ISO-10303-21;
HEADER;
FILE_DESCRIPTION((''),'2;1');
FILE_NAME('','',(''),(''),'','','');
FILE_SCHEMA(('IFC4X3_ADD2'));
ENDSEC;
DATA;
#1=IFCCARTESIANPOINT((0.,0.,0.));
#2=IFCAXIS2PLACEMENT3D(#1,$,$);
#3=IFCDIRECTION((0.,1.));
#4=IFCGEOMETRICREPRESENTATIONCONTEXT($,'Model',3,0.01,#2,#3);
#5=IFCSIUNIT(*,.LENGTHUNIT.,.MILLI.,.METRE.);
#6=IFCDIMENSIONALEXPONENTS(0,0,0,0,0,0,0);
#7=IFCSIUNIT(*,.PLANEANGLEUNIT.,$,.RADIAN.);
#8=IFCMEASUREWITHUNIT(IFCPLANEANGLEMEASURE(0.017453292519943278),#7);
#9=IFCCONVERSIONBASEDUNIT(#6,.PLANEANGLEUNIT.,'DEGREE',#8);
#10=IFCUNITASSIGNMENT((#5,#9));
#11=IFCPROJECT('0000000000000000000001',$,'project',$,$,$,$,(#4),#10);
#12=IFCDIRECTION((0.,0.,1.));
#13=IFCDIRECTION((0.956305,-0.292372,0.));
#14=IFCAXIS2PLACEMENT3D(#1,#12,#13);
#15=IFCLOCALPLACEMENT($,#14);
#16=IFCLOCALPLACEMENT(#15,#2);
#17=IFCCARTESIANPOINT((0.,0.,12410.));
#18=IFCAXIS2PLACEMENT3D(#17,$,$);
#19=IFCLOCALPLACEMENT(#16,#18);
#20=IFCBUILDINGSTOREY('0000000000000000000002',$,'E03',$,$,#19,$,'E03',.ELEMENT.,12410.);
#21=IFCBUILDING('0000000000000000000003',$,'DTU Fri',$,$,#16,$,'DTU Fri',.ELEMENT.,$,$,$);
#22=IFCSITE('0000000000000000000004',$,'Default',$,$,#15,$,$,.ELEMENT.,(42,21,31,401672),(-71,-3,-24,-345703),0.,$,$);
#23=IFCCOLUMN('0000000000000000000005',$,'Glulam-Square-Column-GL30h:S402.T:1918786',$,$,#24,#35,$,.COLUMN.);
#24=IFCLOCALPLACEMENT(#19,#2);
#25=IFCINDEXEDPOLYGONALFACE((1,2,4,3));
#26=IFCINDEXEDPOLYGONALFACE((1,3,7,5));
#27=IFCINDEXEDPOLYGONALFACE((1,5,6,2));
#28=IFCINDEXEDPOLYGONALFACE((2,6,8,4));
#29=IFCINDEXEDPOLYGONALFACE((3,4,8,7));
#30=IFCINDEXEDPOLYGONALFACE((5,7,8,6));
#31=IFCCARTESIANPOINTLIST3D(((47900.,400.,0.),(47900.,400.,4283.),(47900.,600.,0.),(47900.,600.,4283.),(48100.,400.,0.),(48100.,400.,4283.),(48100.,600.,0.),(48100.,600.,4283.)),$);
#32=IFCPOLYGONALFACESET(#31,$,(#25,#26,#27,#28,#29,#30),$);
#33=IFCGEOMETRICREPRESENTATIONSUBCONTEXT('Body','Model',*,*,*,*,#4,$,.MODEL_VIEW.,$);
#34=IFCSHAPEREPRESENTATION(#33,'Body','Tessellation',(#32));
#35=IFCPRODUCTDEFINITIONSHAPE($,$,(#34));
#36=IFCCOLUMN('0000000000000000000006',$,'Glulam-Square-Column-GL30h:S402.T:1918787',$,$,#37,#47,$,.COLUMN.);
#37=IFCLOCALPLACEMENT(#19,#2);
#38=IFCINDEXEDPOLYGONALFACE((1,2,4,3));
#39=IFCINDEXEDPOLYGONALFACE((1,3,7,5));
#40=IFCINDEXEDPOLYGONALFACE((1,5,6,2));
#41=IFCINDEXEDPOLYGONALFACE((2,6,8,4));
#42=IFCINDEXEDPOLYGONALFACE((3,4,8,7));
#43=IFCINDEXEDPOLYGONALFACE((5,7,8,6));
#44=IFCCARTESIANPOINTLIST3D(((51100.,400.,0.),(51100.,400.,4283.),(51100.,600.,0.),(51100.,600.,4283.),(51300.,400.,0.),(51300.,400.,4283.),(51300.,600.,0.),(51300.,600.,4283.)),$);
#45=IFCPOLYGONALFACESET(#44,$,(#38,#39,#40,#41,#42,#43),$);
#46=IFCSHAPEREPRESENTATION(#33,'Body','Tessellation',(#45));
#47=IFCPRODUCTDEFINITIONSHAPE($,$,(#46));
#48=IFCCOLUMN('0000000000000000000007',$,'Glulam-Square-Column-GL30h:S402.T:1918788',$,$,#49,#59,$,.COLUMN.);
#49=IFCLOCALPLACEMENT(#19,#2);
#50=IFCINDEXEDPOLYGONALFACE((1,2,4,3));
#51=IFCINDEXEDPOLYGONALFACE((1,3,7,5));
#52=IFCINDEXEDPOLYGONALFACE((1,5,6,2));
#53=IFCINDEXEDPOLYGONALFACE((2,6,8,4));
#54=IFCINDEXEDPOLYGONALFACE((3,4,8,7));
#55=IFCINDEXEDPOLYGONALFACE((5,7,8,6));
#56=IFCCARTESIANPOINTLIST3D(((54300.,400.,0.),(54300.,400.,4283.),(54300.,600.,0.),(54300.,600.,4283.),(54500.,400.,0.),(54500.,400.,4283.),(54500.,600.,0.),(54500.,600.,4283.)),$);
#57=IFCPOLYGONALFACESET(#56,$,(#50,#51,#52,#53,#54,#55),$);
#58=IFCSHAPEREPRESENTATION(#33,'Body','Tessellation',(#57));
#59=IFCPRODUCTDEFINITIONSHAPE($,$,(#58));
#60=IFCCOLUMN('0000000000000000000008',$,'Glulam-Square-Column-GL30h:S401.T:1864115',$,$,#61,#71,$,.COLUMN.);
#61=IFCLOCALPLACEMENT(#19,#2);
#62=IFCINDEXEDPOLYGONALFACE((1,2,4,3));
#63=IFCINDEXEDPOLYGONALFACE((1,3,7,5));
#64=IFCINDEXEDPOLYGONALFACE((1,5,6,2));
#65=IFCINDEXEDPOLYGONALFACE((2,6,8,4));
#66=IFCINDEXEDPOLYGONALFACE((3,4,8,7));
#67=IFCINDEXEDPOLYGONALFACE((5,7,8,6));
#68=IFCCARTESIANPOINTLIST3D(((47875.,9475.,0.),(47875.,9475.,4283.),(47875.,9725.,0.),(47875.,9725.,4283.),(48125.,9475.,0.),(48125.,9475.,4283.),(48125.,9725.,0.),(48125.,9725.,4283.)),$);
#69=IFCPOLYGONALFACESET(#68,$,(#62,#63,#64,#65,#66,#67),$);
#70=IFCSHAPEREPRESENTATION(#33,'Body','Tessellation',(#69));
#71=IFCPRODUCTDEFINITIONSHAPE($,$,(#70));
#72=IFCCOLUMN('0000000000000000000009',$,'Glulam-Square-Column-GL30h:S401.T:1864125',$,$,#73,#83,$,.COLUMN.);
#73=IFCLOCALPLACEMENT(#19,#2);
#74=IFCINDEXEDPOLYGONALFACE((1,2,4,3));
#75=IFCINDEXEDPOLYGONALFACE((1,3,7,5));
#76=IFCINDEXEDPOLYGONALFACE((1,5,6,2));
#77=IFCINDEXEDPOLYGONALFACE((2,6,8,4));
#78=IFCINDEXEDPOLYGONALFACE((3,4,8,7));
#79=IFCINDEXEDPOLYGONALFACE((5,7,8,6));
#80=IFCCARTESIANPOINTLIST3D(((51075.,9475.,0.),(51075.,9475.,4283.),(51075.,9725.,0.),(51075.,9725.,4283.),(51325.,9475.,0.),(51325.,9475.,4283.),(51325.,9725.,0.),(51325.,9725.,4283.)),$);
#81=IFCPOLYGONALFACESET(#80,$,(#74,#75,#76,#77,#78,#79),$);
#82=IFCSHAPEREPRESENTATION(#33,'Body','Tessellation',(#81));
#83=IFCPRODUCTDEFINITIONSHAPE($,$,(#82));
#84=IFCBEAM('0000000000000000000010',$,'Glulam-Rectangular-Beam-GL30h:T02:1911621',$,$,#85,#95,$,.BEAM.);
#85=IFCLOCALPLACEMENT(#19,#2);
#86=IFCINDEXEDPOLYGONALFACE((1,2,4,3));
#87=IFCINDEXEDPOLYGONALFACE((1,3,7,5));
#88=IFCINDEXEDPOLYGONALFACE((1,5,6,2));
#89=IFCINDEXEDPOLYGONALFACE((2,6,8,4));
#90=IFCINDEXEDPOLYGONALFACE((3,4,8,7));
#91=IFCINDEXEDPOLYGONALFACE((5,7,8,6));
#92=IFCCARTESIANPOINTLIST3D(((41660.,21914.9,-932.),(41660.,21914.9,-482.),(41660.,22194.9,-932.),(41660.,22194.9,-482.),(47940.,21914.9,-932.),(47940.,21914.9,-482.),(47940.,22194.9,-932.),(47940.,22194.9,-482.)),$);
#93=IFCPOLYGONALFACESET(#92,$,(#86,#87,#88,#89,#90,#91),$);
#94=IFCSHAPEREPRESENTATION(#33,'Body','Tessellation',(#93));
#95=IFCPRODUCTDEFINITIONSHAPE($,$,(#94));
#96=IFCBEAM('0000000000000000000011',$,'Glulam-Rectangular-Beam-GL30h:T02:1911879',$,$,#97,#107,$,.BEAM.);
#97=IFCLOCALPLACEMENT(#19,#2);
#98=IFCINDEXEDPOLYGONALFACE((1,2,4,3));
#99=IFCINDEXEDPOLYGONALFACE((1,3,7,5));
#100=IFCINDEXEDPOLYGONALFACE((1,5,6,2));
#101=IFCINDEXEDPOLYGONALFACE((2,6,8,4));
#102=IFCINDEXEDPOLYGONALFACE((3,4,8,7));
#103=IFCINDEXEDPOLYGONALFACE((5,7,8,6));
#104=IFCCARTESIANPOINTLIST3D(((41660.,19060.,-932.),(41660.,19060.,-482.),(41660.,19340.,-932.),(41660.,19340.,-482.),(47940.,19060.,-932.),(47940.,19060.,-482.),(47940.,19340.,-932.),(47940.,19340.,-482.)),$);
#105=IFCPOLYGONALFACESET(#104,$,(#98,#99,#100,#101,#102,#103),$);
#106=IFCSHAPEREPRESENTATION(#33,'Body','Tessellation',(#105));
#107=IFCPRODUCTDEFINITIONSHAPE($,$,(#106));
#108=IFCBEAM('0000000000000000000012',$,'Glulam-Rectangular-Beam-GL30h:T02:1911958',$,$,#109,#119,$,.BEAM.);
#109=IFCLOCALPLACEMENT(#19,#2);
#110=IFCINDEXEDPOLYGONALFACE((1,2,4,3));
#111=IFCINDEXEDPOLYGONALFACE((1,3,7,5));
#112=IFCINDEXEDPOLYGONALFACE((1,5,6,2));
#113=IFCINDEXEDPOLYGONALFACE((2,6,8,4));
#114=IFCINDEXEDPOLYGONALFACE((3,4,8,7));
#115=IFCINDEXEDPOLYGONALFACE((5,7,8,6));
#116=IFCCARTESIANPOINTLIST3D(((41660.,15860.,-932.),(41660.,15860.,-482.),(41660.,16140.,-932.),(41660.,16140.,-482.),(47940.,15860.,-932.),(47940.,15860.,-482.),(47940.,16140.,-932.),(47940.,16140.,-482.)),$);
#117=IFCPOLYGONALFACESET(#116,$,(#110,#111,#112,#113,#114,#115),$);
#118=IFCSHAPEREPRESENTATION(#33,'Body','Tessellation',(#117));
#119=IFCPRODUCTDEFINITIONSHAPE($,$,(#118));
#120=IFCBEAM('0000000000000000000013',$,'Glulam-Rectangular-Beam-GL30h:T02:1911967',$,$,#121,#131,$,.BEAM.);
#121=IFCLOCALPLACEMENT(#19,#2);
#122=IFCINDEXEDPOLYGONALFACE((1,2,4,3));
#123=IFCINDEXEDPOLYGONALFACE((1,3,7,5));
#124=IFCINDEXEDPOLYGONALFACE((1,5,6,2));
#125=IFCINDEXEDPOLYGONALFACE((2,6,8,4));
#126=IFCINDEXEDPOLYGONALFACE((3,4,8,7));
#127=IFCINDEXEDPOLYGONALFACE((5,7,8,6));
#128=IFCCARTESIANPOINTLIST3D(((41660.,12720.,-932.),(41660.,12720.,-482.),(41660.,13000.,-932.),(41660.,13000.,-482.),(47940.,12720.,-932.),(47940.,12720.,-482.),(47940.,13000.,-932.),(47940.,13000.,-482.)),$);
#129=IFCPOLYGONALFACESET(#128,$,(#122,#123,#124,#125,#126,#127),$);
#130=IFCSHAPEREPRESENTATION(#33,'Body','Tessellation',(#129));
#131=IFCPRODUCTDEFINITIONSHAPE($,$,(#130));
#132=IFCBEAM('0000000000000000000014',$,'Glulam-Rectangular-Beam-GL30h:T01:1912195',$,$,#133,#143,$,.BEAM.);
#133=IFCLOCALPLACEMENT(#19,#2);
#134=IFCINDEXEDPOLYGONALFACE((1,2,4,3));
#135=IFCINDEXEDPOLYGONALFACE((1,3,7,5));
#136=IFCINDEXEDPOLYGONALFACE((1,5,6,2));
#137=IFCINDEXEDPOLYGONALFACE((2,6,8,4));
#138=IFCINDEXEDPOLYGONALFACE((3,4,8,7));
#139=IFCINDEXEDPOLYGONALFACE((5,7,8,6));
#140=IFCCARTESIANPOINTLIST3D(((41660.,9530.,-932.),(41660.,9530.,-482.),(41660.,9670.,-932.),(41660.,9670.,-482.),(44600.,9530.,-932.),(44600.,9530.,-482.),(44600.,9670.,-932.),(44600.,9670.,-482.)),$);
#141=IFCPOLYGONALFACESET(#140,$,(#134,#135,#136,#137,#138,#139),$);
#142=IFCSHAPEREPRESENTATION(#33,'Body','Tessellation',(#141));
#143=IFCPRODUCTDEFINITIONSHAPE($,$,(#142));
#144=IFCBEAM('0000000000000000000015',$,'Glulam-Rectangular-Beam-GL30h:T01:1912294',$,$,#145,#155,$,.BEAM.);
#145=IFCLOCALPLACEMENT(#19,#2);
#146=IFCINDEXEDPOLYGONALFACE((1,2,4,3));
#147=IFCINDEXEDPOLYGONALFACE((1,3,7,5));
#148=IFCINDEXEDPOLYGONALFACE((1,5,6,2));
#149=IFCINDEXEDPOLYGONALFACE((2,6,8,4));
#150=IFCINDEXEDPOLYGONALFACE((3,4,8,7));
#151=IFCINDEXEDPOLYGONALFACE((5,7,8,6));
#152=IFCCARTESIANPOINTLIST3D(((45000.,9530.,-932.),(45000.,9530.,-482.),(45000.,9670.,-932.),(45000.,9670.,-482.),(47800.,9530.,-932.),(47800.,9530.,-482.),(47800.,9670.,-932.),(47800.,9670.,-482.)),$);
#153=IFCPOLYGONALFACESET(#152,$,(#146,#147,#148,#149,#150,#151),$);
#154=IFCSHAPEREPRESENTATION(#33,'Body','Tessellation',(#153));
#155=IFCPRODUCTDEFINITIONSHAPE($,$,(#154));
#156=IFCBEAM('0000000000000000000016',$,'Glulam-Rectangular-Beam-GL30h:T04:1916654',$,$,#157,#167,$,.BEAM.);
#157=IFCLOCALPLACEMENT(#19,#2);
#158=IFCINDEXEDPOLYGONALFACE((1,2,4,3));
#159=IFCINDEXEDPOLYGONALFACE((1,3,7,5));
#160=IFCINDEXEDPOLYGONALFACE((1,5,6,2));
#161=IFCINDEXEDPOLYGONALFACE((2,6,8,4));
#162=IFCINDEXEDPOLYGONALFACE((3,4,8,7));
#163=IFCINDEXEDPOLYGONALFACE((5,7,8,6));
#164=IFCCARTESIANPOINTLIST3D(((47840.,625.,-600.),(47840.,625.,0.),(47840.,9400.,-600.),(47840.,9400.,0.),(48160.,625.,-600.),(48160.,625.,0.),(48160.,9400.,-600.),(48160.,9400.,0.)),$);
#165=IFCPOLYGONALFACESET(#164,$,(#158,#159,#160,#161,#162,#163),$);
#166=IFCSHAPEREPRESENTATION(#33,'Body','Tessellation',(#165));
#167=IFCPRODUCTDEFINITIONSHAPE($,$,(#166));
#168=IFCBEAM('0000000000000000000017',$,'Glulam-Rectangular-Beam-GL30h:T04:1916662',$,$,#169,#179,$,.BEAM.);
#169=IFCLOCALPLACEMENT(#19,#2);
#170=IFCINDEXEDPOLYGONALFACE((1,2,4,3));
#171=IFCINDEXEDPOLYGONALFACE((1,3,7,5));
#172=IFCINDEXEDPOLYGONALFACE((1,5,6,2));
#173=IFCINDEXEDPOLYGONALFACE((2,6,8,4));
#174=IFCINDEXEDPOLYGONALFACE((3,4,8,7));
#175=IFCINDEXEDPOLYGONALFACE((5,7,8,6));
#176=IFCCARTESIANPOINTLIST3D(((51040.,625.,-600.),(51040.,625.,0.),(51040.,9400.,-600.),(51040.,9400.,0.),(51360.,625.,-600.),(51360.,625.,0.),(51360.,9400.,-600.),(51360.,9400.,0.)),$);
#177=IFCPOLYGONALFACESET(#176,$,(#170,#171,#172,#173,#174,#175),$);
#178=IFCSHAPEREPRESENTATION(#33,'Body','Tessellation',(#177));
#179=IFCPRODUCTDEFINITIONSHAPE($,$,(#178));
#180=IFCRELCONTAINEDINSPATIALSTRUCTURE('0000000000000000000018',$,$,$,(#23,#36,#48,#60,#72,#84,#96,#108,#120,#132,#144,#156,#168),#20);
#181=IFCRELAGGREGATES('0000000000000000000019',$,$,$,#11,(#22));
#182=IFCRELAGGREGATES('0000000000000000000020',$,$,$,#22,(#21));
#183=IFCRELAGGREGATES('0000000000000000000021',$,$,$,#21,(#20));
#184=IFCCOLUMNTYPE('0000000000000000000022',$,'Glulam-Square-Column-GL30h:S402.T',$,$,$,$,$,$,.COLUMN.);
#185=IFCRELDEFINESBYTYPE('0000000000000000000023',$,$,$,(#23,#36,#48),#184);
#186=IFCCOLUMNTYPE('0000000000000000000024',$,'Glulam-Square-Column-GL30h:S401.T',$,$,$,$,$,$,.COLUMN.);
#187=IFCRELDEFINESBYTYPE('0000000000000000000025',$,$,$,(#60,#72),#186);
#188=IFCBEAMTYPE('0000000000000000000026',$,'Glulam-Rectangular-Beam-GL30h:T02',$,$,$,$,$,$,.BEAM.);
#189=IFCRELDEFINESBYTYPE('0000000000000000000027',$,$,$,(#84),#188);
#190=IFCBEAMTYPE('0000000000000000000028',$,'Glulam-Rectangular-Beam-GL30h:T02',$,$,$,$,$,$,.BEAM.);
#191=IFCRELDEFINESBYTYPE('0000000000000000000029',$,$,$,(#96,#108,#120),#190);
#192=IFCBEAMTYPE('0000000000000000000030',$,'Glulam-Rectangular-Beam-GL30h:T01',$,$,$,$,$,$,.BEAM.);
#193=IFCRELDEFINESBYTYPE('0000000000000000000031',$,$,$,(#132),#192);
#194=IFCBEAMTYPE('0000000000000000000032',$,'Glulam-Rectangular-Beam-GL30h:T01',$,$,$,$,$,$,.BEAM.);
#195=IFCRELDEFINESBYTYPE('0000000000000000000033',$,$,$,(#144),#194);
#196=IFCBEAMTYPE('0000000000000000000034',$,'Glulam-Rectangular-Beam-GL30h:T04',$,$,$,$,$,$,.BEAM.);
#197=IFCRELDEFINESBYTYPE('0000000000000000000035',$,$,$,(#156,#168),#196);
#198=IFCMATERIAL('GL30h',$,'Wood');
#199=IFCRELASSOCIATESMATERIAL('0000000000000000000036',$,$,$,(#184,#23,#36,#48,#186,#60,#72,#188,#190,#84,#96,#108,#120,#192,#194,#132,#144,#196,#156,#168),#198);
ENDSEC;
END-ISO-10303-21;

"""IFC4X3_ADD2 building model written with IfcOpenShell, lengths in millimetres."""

from ifc_helpers import new_model, entity, si_unit, converted_unit, direction, frame, origin, origin_2d_with_axis, place, context, subcontext, project, spatial, rectangle, extrude, source, transform, mapped, material, material_profile, profile_set, profile_usage, type_object, type_shapes, element, save


model = new_model("IFC4X3_ADD2")

# Units and contexts
model_context = context("Model", 3, precision=0.01, world=origin(), true_north=direction((0.0, 1.0)))
body_context = subcontext(model_context, "Body", "Model", "MODEL_VIEW")
ifc_project = project(units=[si_unit("LENGTHUNIT", "METRE", prefix="MILLI"), converted_unit("PLANEANGLEUNIT", "DEGREE", entity("IfcPlaneAngleMeasure", 0.017453292519943278), si_unit("PLANEANGLEUNIT", "RADIAN"), dimensions=[0, 0, 0, 0, 0, 0, 0])], contexts=[model_context])

# Site, building, storey
site_placement = place(None, frame((0.0, 0.0, 0.0), z_axis=(0.0, 0.0, 1.0), x_axis=(0.956305, -0.292372, 0.0)))
site = spatial("IfcSite", under=ifc_project, at=site_placement, Name="Default", CompositionType="ELEMENT", RefLatitude=(42, 21, 31, 401672), RefLongitude=(-71, -3, -24, -345703), RefElevation=0.0)
building_placement = place(site_placement, origin())
building = spatial("IfcBuilding", under=site, at=building_placement, Name="DTU Fri", LongName="DTU Fri", CompositionType="ELEMENT")
storey_placement = place(building_placement, frame((0.0, 0.0, 12410.0)))
storey = spatial("IfcBuildingStorey", under=building, at=storey_placement, Name="E03", LongName="E03", CompositionType="ELEMENT", Elevation=12410.0)

# Columns
ifc_material_1 = material(Name="GL30h", Category="Wood")
ifc_material_profile_1 = material_profile(ifc_material_1, rectangle(XDim=200.0, YDim=200.0, at=origin_2d_with_axis()), Name="S402.T")
ifc_profile_set_1 = profile_set([ifc_material_profile_1], Name="S402.T")
ifc_profile_usage_1 = profile_usage(ifc_profile_set_1)
column_type_1 = type_object("IfcColumnType", Name="Glulam-Square-Column-GL30h:S402.T", PredefinedType="COLUMN", material=ifc_profile_set_1)
shared_shape_1 = source(origin(), body_context, "Body", "SweptSolid", [
    extrude(rectangle(XDim=200.0, YDim=200.0, at=origin_2d_with_axis()), frame((0.0, 0.0, 12410.0), z_axis=(0.0, 0.0, 1.0), x_axis=(0.0, 1.0, 0.0)), (0.0, 0.0, 1.0), 4283.0),
])
type_shapes(column_type_1, [shared_shape_1])
for number, where, name in (
    (1, (48000.0, 500.0, -12410.0), "Glulam-Square-Column-GL30h:S402.T:1918786"),
    (2, (51200.0, 500.0, -12410.0), "Glulam-Square-Column-GL30h:S402.T:1918787"),
    (3, (54400.0, 500.0, -12410.0), "Glulam-Square-Column-GL30h:S402.T:1918788"),
):
    element("IfcColumn", number, at=place(storey_placement, frame(where)), inside=storey, type_object=column_type_1, material=ifc_profile_usage_1, Name=name, PredefinedType="COLUMN", context=body_context, shape_type="MappedRepresentation", body=[
        mapped(shared_shape_1, transform((0.0, 0.0, 0.0), scale=1.0)),
    ])
ifc_material_profile_2 = material_profile(ifc_material_1, rectangle(XDim=250.0, YDim=250.0, at=origin_2d_with_axis()), Name="S401.T")
ifc_profile_set_2 = profile_set([ifc_material_profile_2], Name="S401.T")
ifc_profile_usage_2 = profile_usage(ifc_profile_set_2)
column_type_2 = type_object("IfcColumnType", Name="Glulam-Square-Column-GL30h:S401.T", PredefinedType="COLUMN", material=ifc_profile_set_2)
shared_shape_2 = source(origin(), body_context, "Body", "SweptSolid", [
    extrude(rectangle(XDim=250.0, YDim=250.0, at=origin_2d_with_axis()), frame((0.0, 0.0, 12410.0), z_axis=(0.0, 0.0, 1.0), x_axis=(0.0, 1.0, 0.0)), (0.0, 0.0, 1.0), 4283.0),
])
type_shapes(column_type_2, [shared_shape_2])
for number, where, name in (
    (4, (48000.0, 9600.0, -12410.0), "Glulam-Square-Column-GL30h:S401.T:1864115"),
    (5, (51200.0, 9600.0, -12410.0), "Glulam-Square-Column-GL30h:S401.T:1864125"),
):
    element("IfcColumn", number, at=place(storey_placement, frame(where)), inside=storey, type_object=column_type_2, material=ifc_profile_usage_2, Name=name, PredefinedType="COLUMN", context=body_context, shape_type="MappedRepresentation", body=[
        mapped(shared_shape_2, transform((0.0, 0.0, 0.0), scale=1.0)),
    ])

# Beams
ifc_material_profile_3 = material_profile(ifc_material_1, rectangle(XDim=450.0, YDim=280.0, at=origin_2d_with_axis()), Name="T02")
ifc_profile_set_3 = profile_set([ifc_material_profile_3], Name="T02")
ifc_profile_usage_3 = profile_usage(ifc_profile_set_3, cardinal=8)
beam_type_1 = type_object("IfcBeamType", Name="Glulam-Rectangular-Beam-GL30h:T02", PredefinedType="BEAM", material=ifc_profile_set_3)
shared_shape_3 = source(origin(), body_context, "Body", "SweptSolid", [
    extrude(rectangle(XDim=450.0, YDim=280.0, at=origin_2d_with_axis()), frame((-3140.0, 0.0, 0.0), z_axis=(1.0, 0.0, 0.0), x_axis=(0.0, 0.0, -1.0)), (0.0, 0.0, 1.0), 6280.0),
])
type_shapes(beam_type_1, [shared_shape_3])
beam_1_placement = place(storey_placement, frame((44800.0, 22054.9, -707.0)))
element("IfcBeam", 6, at=beam_1_placement, inside=storey, type_object=beam_type_1, material=ifc_profile_usage_3, Name="Glulam-Rectangular-Beam-GL30h:T02:1911621", PredefinedType="BEAM", context=body_context, shape_type="MappedRepresentation", body=[
    mapped(shared_shape_3, transform((0.0, 0.0, 0.0), scale=1.0)),
])
beam_type_2 = type_object("IfcBeamType", Name="Glulam-Rectangular-Beam-GL30h:T02", PredefinedType="BEAM", material=ifc_profile_set_3)
shared_shape_4 = source(origin(), body_context, "Body", "SweptSolid", [
    extrude(rectangle(XDim=450.0, YDim=280.0, at=origin_2d_with_axis()), frame((-3140.0, 0.0, 0.0), z_axis=(1.0, 0.0, 0.0), x_axis=(0.0, 0.0, -1.0)), (0.0, 0.0, 1.0), 6280.0),
])
type_shapes(beam_type_2, [shared_shape_4])
for number, where, name in (
    (7, (44800.0, 19200.0, -707.0), "Glulam-Rectangular-Beam-GL30h:T02:1911879"),
    (8, (44800.0, 16000.0, -707.0), "Glulam-Rectangular-Beam-GL30h:T02:1911958"),
    (9, (44800.0, 12860.0, -707.0), "Glulam-Rectangular-Beam-GL30h:T02:1911967"),
):
    element("IfcBeam", number, at=place(storey_placement, frame(where)), inside=storey, type_object=beam_type_2, material=ifc_profile_usage_3, Name=name, PredefinedType="BEAM", context=body_context, shape_type="MappedRepresentation", body=[
        mapped(shared_shape_4, transform((0.0, 0.0, 0.0), scale=1.0)),
    ])
ifc_material_profile_4 = material_profile(ifc_material_1, rectangle(XDim=450.0, YDim=140.0, at=origin_2d_with_axis()), Name="T01")
ifc_profile_set_4 = profile_set([ifc_material_profile_4], Name="T01")
ifc_profile_usage_4 = profile_usage(ifc_profile_set_4, cardinal=8)
beam_type_3 = type_object("IfcBeamType", Name="Glulam-Rectangular-Beam-GL30h:T01", PredefinedType="BEAM", material=ifc_profile_set_4)
shared_shape_5 = source(origin(), body_context, "Body", "SweptSolid", [
    extrude(rectangle(XDim=450.0, YDim=140.0, at=origin_2d_with_axis()), frame((-1540.0, 0.0, 0.0), z_axis=(1.0, 0.0, 0.0), x_axis=(0.0, 0.0, -1.0)), (0.0, 0.0, 1.0), 2940.0),
])
type_shapes(beam_type_3, [shared_shape_5])
beam_2_placement = place(storey_placement, frame((43200.0, 9600.0, -707.0)))
element("IfcBeam", 10, at=beam_2_placement, inside=storey, type_object=beam_type_3, material=ifc_profile_usage_4, Name="Glulam-Rectangular-Beam-GL30h:T01:1912195", PredefinedType="BEAM", context=body_context, shape_type="MappedRepresentation", body=[
    mapped(shared_shape_5, transform((0.0, 0.0, 0.0), scale=1.0)),
])
beam_type_4 = type_object("IfcBeamType", Name="Glulam-Rectangular-Beam-GL30h:T01", PredefinedType="BEAM", material=ifc_profile_set_4)
shared_shape_6 = source(origin(), body_context, "Body", "SweptSolid", [
    extrude(rectangle(XDim=450.0, YDim=140.0, at=origin_2d_with_axis()), frame((-1400.0, 0.0, 0.0), z_axis=(1.0, 0.0, 0.0), x_axis=(0.0, 0.0, -1.0)), (0.0, 0.0, 1.0), 2800.0),
])
type_shapes(beam_type_4, [shared_shape_6])
beam_3_placement = place(storey_placement, frame((46400.0, 9600.0, -707.0)))
element("IfcBeam", 11, at=beam_3_placement, inside=storey, type_object=beam_type_4, material=ifc_profile_usage_4, Name="Glulam-Rectangular-Beam-GL30h:T01:1912294", PredefinedType="BEAM", context=body_context, shape_type="MappedRepresentation", body=[
    mapped(shared_shape_6, transform((0.0, 0.0, 0.0), scale=1.0)),
])
ifc_material_profile_5 = material_profile(ifc_material_1, rectangle(XDim=600.0, YDim=320.0, at=origin_2d_with_axis()), Name="T04")
ifc_profile_set_5 = profile_set([ifc_material_profile_5], Name="T04")
ifc_profile_usage_5 = profile_usage(ifc_profile_set_5, cardinal=8)
beam_type_5 = type_object("IfcBeamType", Name="Glulam-Rectangular-Beam-GL30h:T04", PredefinedType="BEAM", material=ifc_profile_set_5)
shared_shape_7 = source(origin(), body_context, "Body", "SweptSolid", [
    extrude(rectangle(XDim=600.0, YDim=320.0, at=origin_2d_with_axis()), frame((-4350.0, 0.0, 0.0), z_axis=(1.0, 0.0, 0.0), x_axis=(0.0, 0.0, -1.0)), (0.0, 0.0, 1.0), 8775.0),
])
type_shapes(beam_type_5, [shared_shape_7])
for number, where, z_axis, x_axis, name in (
    (12, (48000.0, 5050.0, -300.0), (0.0, 0.0, 1.0), (0.0, -1.0, 0.0), "Glulam-Rectangular-Beam-GL30h:T04:1916654"),
    (13, (51200.0, 5050.0, -300.0), (0.0, 0.0, 1.0), (0.0, -1.0, 0.0), "Glulam-Rectangular-Beam-GL30h:T04:1916662"),
):
    element("IfcBeam", number, at=place(storey_placement, frame(where, z_axis=z_axis, x_axis=x_axis)), inside=storey, type_object=beam_type_5, material=ifc_profile_usage_5, Name=name, PredefinedType="BEAM", context=body_context, shape_type="MappedRepresentation", body=[
        mapped(shared_shape_7, transform((0.0, 0.0, 0.0), scale=1.0)),
    ])

save(model, "model.ifc")
